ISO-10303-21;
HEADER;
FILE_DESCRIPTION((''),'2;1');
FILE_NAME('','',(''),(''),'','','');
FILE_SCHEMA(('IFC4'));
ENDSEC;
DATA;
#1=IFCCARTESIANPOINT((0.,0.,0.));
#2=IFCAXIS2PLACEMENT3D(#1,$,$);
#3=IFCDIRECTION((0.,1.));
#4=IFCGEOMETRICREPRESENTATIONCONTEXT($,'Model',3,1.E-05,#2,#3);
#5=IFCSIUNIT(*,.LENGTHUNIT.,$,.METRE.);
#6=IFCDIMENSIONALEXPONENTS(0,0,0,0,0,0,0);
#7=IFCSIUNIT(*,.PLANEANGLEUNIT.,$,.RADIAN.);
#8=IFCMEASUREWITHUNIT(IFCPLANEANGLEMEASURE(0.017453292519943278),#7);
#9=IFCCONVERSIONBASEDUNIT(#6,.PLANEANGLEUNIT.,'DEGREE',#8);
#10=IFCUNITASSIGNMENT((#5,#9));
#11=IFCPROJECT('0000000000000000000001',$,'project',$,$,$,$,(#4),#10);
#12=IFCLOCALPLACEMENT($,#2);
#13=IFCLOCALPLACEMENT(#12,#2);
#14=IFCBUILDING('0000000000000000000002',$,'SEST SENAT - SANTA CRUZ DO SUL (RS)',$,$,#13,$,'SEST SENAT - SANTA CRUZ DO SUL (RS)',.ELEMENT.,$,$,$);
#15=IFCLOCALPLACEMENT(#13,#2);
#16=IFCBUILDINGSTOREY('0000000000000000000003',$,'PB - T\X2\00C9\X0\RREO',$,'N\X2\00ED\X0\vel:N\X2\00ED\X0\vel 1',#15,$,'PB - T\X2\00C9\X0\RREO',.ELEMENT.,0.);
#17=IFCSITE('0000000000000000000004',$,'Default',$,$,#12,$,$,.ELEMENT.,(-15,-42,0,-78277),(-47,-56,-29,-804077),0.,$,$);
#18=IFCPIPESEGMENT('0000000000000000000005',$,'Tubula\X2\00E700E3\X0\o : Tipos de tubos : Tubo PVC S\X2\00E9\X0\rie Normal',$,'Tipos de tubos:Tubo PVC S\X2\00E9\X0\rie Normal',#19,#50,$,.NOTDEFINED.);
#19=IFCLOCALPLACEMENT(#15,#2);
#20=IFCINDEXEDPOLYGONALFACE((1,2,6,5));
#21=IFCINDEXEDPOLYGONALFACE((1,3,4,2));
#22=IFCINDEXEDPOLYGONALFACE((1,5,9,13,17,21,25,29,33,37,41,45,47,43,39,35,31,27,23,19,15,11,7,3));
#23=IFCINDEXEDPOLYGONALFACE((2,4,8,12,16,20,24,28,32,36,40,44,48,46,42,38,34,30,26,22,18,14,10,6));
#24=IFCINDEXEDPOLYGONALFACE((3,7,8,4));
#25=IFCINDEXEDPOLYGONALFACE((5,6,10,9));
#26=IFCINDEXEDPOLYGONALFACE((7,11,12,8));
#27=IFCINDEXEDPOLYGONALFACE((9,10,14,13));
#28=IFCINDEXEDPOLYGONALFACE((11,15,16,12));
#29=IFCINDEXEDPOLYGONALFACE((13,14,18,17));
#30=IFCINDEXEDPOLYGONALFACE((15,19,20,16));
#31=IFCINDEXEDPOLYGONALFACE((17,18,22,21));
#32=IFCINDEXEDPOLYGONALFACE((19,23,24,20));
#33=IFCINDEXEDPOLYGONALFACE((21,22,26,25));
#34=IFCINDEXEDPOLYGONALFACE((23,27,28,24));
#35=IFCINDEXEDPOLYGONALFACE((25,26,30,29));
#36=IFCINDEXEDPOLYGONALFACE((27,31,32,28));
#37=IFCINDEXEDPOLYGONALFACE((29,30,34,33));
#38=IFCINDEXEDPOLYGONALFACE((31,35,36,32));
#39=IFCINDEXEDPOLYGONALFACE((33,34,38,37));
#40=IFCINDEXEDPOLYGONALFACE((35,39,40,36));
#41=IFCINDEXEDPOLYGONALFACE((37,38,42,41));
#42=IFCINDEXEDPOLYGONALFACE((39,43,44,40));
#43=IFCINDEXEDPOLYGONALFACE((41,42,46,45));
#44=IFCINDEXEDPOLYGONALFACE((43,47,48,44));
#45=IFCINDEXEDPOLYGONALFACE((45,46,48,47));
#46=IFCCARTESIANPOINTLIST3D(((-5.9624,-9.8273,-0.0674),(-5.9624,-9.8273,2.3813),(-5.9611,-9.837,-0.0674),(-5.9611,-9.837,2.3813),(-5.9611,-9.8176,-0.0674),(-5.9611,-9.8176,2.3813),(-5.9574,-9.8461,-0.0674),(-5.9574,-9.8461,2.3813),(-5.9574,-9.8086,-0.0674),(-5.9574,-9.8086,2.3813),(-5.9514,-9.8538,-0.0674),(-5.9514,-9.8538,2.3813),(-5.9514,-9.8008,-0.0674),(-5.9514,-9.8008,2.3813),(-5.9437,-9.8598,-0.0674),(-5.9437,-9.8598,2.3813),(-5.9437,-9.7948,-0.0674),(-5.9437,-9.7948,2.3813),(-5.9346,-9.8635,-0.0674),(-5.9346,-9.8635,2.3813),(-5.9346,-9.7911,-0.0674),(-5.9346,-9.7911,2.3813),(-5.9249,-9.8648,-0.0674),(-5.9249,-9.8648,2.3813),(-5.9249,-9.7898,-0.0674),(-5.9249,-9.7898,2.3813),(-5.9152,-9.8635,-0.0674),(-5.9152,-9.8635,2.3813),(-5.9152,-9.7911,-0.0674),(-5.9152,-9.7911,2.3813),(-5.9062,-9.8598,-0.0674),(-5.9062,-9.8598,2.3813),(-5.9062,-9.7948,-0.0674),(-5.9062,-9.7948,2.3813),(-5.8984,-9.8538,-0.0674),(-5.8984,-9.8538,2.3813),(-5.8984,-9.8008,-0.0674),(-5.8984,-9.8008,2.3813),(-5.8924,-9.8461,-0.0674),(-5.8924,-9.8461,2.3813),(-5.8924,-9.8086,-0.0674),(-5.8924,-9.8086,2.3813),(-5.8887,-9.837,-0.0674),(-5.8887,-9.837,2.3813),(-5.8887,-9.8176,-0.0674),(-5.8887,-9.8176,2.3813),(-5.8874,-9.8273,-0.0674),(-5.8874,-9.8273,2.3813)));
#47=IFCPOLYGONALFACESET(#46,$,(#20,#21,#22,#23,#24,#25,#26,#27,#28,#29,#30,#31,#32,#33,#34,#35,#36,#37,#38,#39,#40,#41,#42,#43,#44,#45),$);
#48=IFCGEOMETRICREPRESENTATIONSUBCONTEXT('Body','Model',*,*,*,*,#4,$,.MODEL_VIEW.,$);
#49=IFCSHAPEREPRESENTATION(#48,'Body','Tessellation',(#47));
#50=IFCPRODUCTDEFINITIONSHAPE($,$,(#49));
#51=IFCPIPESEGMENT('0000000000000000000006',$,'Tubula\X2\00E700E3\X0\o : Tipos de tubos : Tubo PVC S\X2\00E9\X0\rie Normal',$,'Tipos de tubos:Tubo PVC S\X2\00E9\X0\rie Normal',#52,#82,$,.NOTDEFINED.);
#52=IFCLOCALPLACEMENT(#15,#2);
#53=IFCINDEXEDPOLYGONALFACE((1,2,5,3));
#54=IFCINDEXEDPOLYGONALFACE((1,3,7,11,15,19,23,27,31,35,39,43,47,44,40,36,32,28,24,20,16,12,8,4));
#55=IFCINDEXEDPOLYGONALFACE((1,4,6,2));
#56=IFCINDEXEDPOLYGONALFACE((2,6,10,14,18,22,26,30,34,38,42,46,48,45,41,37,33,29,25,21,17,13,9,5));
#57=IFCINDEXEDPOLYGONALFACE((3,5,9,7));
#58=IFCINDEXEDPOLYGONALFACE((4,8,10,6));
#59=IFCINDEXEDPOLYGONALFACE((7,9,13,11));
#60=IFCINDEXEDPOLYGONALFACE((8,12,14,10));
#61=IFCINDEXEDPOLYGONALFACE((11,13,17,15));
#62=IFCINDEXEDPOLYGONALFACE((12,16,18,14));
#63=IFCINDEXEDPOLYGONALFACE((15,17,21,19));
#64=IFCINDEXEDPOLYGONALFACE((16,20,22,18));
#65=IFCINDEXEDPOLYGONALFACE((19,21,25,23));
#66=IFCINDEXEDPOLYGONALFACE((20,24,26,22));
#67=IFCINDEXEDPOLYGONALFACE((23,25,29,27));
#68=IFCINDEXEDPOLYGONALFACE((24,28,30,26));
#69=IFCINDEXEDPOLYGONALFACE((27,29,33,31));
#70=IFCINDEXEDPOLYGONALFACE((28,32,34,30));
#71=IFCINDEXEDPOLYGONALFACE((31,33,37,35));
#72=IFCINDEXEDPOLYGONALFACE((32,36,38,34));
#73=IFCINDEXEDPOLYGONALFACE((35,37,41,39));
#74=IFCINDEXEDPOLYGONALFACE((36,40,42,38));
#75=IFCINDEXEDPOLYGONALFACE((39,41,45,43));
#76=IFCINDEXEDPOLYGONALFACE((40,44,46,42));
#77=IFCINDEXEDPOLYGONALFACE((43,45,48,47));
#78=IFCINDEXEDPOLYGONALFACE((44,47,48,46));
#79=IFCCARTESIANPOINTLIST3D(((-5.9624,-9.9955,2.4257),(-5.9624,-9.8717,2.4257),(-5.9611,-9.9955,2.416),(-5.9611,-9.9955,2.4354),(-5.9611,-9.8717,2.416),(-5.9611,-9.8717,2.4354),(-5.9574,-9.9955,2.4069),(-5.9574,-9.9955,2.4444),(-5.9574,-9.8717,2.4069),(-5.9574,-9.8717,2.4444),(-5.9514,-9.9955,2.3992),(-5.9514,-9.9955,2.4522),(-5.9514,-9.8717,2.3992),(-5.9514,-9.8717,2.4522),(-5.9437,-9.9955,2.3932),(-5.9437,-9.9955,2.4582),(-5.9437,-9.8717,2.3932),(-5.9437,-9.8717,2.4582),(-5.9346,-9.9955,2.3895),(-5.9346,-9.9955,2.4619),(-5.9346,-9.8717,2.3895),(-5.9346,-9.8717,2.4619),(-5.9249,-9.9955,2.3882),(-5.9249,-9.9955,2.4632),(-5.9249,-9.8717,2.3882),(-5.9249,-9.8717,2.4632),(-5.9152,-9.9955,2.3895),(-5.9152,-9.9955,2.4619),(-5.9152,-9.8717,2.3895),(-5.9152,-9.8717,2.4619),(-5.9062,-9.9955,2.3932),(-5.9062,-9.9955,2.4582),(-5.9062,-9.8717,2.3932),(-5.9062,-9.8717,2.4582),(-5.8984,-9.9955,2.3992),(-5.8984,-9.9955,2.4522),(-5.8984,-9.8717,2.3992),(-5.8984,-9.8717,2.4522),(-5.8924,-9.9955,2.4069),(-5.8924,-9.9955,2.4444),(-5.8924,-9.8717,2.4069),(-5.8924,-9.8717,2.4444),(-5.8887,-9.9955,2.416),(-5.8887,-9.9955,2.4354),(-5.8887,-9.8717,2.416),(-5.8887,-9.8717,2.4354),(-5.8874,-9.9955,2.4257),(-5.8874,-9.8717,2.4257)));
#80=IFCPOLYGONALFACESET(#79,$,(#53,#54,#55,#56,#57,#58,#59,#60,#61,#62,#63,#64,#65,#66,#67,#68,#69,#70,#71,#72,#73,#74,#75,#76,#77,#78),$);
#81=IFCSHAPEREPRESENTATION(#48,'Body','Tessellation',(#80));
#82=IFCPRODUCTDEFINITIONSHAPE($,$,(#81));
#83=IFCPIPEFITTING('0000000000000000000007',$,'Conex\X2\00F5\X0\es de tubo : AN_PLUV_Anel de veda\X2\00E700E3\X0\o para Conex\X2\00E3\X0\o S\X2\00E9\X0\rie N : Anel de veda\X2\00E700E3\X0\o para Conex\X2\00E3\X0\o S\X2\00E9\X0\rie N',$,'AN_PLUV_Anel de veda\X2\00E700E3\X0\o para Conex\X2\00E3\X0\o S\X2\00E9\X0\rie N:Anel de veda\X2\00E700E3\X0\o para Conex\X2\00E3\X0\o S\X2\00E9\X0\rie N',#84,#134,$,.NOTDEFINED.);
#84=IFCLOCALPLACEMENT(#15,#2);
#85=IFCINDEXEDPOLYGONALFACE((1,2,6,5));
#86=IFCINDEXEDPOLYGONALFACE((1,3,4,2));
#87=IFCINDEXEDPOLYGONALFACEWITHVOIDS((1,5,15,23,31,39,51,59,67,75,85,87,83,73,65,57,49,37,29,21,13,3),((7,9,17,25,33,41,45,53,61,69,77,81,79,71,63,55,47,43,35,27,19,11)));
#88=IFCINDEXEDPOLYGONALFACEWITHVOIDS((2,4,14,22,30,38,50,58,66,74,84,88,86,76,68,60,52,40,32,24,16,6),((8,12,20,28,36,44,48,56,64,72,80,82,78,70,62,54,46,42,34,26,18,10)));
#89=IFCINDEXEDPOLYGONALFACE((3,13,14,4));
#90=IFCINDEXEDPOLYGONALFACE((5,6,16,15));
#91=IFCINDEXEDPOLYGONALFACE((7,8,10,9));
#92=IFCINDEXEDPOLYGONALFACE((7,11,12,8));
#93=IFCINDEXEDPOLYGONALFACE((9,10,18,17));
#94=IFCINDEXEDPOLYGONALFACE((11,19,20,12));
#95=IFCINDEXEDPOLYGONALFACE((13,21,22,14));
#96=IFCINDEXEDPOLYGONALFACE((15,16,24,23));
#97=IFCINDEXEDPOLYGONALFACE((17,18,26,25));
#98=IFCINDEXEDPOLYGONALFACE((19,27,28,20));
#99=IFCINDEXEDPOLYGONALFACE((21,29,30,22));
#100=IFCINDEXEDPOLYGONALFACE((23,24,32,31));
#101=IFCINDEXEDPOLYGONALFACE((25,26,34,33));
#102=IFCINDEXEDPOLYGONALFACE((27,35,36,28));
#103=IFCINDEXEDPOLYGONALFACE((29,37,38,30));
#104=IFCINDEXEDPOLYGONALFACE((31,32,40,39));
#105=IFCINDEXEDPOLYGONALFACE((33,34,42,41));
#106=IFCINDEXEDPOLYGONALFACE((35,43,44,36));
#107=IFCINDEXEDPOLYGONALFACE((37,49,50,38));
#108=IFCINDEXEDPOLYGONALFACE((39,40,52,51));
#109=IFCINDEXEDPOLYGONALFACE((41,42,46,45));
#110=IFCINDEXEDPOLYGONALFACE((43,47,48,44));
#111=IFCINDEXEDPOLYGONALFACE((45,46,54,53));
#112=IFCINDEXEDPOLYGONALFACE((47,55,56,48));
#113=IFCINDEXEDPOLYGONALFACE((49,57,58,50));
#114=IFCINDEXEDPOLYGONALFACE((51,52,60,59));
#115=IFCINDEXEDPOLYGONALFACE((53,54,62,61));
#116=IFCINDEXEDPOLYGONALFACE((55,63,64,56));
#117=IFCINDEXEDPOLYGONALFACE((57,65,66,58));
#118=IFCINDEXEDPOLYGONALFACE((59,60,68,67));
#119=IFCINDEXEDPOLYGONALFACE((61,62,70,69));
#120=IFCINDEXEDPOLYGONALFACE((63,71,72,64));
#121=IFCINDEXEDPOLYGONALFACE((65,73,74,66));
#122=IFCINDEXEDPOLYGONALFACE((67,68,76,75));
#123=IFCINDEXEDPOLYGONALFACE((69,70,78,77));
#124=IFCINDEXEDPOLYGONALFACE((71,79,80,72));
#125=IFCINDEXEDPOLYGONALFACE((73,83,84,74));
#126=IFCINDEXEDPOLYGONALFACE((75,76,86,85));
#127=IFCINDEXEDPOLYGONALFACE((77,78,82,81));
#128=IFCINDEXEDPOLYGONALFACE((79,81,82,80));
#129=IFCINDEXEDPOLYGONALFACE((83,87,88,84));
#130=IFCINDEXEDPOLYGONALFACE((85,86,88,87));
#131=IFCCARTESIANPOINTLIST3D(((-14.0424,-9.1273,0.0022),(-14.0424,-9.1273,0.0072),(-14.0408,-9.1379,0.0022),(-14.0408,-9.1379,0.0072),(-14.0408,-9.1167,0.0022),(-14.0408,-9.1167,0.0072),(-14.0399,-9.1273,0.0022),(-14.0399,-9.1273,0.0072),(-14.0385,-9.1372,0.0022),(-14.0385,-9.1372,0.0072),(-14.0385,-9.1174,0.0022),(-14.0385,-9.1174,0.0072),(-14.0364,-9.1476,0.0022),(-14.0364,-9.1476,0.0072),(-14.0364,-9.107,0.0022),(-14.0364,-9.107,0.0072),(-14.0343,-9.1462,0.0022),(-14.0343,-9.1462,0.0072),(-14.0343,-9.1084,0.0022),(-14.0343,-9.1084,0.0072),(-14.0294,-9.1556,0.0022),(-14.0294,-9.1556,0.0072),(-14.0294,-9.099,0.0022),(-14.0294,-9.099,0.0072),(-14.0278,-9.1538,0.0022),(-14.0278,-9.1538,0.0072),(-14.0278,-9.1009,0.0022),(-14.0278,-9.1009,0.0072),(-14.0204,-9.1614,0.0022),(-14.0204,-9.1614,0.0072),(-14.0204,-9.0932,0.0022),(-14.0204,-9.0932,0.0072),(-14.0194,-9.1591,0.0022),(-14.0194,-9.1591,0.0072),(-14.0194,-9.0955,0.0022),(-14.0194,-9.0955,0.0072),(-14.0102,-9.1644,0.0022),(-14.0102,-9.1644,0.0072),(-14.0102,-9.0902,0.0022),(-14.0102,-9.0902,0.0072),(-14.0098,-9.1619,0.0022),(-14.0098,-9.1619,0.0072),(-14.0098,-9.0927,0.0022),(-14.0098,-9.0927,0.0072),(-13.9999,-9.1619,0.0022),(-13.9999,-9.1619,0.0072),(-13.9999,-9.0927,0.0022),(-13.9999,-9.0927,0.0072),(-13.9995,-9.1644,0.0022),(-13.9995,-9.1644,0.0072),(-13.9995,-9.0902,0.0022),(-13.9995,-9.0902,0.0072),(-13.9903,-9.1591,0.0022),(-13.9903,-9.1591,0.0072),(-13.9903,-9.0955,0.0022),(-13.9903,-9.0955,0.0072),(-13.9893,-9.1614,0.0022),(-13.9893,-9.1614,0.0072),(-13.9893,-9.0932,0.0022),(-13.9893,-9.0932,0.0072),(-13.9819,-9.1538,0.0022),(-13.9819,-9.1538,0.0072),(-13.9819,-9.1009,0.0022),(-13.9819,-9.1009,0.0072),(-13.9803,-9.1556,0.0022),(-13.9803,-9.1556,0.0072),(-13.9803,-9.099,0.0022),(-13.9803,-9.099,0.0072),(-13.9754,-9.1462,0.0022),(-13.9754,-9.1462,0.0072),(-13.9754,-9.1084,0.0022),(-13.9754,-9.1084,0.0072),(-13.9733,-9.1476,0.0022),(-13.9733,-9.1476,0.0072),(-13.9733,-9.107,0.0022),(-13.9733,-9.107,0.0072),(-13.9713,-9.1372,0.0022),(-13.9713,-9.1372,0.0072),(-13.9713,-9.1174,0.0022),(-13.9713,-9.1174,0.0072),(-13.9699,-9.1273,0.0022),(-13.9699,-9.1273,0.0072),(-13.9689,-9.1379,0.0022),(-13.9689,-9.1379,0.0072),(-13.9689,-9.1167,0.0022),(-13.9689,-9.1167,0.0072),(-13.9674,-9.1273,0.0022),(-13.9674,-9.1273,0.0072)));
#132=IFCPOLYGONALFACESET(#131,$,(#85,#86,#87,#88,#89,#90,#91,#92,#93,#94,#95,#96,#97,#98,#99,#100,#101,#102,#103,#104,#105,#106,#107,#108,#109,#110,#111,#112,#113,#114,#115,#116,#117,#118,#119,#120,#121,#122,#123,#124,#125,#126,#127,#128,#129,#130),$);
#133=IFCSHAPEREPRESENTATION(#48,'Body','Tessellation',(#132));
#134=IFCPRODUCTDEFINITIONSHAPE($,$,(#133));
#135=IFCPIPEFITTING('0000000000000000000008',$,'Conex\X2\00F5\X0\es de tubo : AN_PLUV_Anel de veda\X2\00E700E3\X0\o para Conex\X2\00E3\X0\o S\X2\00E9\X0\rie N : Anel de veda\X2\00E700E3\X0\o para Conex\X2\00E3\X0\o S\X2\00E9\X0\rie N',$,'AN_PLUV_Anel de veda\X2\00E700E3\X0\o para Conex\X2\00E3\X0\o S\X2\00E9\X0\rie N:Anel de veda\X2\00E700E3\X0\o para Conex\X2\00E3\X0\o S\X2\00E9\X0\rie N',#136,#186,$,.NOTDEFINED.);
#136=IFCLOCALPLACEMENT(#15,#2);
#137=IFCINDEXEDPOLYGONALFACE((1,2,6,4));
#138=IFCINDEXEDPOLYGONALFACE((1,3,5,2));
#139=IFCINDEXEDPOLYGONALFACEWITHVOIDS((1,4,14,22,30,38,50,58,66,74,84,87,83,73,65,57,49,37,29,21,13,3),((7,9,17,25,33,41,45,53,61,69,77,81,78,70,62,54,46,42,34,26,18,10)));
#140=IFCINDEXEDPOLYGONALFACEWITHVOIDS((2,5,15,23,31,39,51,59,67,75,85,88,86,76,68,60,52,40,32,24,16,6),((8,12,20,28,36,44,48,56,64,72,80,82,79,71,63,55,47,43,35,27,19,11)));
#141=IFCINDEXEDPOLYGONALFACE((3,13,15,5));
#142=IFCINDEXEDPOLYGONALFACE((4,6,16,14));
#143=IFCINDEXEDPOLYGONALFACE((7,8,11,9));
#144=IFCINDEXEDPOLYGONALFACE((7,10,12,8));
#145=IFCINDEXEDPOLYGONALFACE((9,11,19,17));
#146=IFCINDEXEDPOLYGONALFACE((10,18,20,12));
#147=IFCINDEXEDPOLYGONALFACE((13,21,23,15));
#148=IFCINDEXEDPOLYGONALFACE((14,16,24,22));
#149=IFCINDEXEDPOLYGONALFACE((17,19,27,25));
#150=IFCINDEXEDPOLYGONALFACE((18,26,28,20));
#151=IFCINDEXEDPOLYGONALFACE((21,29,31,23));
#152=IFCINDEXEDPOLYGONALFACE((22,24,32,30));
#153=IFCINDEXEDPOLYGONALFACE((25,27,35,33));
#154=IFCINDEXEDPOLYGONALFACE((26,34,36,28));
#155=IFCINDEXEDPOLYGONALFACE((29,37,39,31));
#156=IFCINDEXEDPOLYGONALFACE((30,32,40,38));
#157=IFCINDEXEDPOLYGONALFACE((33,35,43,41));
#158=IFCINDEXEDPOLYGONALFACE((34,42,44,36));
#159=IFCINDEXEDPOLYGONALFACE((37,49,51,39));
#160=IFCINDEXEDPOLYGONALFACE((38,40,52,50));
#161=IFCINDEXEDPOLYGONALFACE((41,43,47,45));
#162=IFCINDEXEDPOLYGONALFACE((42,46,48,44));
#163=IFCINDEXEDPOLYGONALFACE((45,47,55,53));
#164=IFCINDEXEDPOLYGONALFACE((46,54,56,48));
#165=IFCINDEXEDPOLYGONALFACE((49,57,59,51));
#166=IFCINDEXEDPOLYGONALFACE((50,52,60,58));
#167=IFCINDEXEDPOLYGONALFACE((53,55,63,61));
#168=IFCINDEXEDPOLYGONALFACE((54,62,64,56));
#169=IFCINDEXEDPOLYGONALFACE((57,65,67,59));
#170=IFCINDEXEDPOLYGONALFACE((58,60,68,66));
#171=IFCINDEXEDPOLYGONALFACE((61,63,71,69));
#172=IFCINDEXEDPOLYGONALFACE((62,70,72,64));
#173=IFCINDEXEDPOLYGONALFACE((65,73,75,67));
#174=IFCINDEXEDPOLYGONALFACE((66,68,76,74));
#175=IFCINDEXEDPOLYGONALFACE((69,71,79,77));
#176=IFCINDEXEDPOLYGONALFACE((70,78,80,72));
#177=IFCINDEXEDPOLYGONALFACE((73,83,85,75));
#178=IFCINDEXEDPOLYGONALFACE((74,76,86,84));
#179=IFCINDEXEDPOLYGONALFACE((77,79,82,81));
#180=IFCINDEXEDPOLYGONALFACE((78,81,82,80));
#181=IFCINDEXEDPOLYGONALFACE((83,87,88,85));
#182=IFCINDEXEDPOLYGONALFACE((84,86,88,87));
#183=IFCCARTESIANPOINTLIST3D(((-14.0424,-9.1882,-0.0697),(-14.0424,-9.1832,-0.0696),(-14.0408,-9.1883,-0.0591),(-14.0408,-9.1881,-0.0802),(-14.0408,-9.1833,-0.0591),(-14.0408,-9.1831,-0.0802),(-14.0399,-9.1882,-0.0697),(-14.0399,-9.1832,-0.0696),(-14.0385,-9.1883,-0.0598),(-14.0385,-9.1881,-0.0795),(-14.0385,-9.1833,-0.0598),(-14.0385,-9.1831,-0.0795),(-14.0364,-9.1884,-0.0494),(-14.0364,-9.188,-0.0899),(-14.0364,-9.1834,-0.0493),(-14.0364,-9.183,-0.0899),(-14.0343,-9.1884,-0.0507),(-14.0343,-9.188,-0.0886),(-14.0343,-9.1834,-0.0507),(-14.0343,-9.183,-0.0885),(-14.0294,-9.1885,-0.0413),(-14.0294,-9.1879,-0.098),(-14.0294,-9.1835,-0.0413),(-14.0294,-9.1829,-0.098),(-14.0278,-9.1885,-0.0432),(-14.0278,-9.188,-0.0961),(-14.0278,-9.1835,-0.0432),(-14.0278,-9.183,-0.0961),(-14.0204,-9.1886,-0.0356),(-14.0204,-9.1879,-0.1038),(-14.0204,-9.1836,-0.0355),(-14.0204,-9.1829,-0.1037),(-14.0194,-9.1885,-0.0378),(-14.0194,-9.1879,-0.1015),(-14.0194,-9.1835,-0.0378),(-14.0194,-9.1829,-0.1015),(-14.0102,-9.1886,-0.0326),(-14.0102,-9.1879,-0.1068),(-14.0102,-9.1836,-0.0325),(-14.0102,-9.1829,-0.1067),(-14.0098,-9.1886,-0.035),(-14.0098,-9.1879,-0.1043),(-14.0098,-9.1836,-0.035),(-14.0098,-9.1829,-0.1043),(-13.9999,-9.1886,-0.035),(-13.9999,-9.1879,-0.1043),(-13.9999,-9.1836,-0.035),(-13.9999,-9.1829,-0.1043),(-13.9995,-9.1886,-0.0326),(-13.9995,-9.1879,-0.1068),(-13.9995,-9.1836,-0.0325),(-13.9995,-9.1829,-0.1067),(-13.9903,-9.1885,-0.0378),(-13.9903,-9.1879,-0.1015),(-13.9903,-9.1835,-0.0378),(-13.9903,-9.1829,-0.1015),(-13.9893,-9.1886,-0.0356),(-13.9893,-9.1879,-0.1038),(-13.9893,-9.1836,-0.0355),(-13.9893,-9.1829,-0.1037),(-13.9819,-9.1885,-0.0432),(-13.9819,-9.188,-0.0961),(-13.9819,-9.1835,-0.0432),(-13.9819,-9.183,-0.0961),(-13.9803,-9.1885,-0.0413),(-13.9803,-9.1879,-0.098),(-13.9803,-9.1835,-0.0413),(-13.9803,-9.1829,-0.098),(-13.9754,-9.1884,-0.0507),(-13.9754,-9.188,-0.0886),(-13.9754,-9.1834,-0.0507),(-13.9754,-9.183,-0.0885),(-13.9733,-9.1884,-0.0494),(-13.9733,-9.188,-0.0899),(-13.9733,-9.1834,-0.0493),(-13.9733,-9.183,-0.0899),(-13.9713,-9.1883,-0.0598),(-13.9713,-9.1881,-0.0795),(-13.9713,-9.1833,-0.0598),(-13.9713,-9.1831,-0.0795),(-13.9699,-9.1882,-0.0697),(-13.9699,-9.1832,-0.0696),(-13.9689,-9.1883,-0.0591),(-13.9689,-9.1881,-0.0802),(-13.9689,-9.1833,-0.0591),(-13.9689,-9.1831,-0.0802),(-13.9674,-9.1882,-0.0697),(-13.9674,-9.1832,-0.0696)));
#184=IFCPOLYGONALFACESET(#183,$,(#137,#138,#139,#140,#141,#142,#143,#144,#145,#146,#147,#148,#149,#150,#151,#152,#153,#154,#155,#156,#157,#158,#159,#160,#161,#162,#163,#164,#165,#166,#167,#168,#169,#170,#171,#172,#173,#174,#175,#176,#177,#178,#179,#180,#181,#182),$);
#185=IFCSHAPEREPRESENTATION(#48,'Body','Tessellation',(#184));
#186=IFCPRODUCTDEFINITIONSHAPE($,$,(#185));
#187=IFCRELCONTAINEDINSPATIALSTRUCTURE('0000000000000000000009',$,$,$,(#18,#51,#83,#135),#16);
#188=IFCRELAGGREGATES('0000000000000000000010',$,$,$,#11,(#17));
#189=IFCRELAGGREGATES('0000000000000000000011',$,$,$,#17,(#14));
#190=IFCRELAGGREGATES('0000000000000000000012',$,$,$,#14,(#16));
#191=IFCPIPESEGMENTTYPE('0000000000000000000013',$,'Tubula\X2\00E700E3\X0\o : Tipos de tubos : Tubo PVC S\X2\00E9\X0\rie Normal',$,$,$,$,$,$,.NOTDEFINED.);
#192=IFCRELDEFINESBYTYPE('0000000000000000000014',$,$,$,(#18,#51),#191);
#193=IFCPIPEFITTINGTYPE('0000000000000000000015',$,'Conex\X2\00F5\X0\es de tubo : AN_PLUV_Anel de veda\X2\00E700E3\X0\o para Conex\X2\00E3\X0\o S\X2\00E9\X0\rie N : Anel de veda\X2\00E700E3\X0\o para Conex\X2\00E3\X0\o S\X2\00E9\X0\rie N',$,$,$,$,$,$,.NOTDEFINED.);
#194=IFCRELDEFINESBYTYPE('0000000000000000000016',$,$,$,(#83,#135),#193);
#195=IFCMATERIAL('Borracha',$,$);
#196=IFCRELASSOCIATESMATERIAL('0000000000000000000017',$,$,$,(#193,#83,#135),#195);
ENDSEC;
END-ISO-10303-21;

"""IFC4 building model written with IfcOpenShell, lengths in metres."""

from ifc_helpers import new_model, entity, si_unit, converted_unit, direction, frame, origin, place, context, subcontext, project, spatial, arc, indexed_curve, outline, extrude, source, transform, mapped, material, type_object, type_shapes, element, save


model = new_model("IFC4")

# Units and contexts
model_context = context("Model", 3, precision=1e-05, world=origin(), true_north=direction((0.0, 1.0)))
body_context = subcontext(model_context, "Body", "Model", "MODEL_VIEW")
ifc_project = project(units=[si_unit("LENGTHUNIT", "METRE"), converted_unit("PLANEANGLEUNIT", "DEGREE", entity("IfcPlaneAngleMeasure", 0.017453292519943278), si_unit("PLANEANGLEUNIT", "RADIAN"), dimensions=[0, 0, 0, 0, 0, 0, 0])], contexts=[model_context])

# Site, building, storey
site_placement = place(None, origin())
site = spatial("IfcSite", under=ifc_project, at=site_placement, Name="Default", CompositionType="ELEMENT", RefLatitude=(-15, -42, 0, -78277), RefLongitude=(-47, -56, -29, -804077), RefElevation=0.0)
building_placement = place(site_placement, origin())
building = spatial("IfcBuilding", under=site, at=building_placement, Name="SEST SENAT - SANTA CRUZ DO SUL (RS)", LongName="SEST SENAT - SANTA CRUZ DO SUL (RS)", CompositionType="ELEMENT")
storey_placement = place(building_placement, origin())
storey = spatial("IfcBuildingStorey", under=building, at=storey_placement, Name="PB - TÉRREO", ObjectType="Nível:Nível 1", LongName="PB - TÉRREO", CompositionType="ELEMENT", Elevation=0.0)

# Pipe segments
pipe_segment_type_1 = type_object("IfcPipeSegmentType", Name="Tubulação : Tipos de tubos : Tubo PVC Série Normal", PredefinedType="NOTDEFINED")
pipe_segment_1_placement = place(storey_placement, frame((-5.964, -9.8664, -0.0674)))
element("IfcPipeSegment", 1, at=pipe_segment_1_placement, inside=storey, type_object=pipe_segment_type_1, Name="Tubulação : Tipos de tubos : Tubo PVC Série Normal", ObjectType="Tipos de tubos:Tubo PVC Série Normal", PredefinedType="NOTDEFINED", context=body_context, shape_type="SweptSolid", body=[
    extrude(outline(indexed_curve([(0.0375, 0.0), (0.0265, 0.0265), (0.0, 0.0375), (-0.0265, 0.0265), (-0.0375, 0.0), (-0.0265, -0.0265), (0.0, -0.0375), (0.0265, -0.0265)], segments=[arc(1, 2, 3), arc(3, 4, 5), arc(5, 6, 7), arc(7, 8, 1)], self_intersect=False)), frame((0.0391, 0.0391, 0.0)), (0.0, 0.0, 1.0), 2.4487),
])
pipe_segment_2_placement = place(storey_placement, frame((-5.964, -9.9955, 2.3866)))
element("IfcPipeSegment", 2, at=pipe_segment_2_placement, inside=storey, type_object=pipe_segment_type_1, Name="Tubulação : Tipos de tubos : Tubo PVC Série Normal", ObjectType="Tipos de tubos:Tubo PVC Série Normal", PredefinedType="NOTDEFINED", context=body_context, shape_type="SweptSolid", body=[
    extrude(outline(indexed_curve([(0.0375, 0.0), (0.0265, 0.0265), (0.0, 0.0375), (-0.0265, 0.0265), (-0.0375, 0.0), (-0.0265, -0.0265), (0.0, -0.0375), (0.0265, -0.0265)], segments=[arc(1, 2, 3), arc(3, 4, 5), arc(5, 6, 7), arc(7, 8, 1)], self_intersect=False)), frame((0.0391, 0.0, 0.0391), z_axis=(0.0, 1.0, 0.0), x_axis=(-1.0, 0.0, 0.0)), (0.0, 0.0, 1.0), 0.1238),
])

# Pipe fittings
ifc_material = material(Name="Borracha")
pipe_fitting_type = type_object("IfcPipeFittingType", Name="Conexões de tubo : AN_PLUV_Anel de vedação para Conexão Série N : Anel de vedação para Conexão Série N", PredefinedType="NOTDEFINED", material=ifc_material)
shared_shape = source(origin(), body_context, "Body", "SweptSolid", [
    extrude(outline(indexed_curve([(-0.0375, 0.0), (0.0, -0.0375), (0.0375, 0.0), (0.0, 0.0375)], segments=[arc(1, 2, 3), arc(3, 4, 1)], self_intersect=False), holes=[indexed_curve([(-0.035, 0.0), (0.0, 0.035), (0.035, 0.0), (0.0, -0.035)], segments=[arc(1, 2, 3), arc(3, 4, 1)], self_intersect=False)]), frame((0.0, 0.0, -0.005)), (0.0, 0.0, 1.0), 0.005),
])
type_shapes(pipe_fitting_type, [shared_shape])
for number, where, z_axis, x_axis, name in (
    (3, (-14.0049, -9.1273, 0.0072), (0.0, 0.0, 1.0), (-1.0, 0.0, 0.0), "Conexões de tubo : AN_PLUV_Anel de vedação para Conexão Série N : Anel de vedação para Conexão Série N"),
    (4, (-14.0049, -9.1832, -0.0696), (0.0, 0.99995, 0.01), (-1.0, 0.0, 0.0), "Conexões de tubo : AN_PLUV_Anel de vedação para Conexão Série N : Anel de vedação para Conexão Série N"),
):
    element("IfcPipeFitting", number, at=place(storey_placement, frame(where, z_axis=z_axis, x_axis=x_axis)), inside=storey, type_object=pipe_fitting_type, material=ifc_material, Name=name, ObjectType="AN_PLUV_Anel de vedação para Conexão Série N:Anel de vedação para Conexão Série N", PredefinedType="NOTDEFINED", context=body_context, shape_type="MappedRepresentation", body=[
        mapped(shared_shape, transform((0.0, 0.0, 0.0), scale=1.0)),
    ])

save(model, "model.ifc")
